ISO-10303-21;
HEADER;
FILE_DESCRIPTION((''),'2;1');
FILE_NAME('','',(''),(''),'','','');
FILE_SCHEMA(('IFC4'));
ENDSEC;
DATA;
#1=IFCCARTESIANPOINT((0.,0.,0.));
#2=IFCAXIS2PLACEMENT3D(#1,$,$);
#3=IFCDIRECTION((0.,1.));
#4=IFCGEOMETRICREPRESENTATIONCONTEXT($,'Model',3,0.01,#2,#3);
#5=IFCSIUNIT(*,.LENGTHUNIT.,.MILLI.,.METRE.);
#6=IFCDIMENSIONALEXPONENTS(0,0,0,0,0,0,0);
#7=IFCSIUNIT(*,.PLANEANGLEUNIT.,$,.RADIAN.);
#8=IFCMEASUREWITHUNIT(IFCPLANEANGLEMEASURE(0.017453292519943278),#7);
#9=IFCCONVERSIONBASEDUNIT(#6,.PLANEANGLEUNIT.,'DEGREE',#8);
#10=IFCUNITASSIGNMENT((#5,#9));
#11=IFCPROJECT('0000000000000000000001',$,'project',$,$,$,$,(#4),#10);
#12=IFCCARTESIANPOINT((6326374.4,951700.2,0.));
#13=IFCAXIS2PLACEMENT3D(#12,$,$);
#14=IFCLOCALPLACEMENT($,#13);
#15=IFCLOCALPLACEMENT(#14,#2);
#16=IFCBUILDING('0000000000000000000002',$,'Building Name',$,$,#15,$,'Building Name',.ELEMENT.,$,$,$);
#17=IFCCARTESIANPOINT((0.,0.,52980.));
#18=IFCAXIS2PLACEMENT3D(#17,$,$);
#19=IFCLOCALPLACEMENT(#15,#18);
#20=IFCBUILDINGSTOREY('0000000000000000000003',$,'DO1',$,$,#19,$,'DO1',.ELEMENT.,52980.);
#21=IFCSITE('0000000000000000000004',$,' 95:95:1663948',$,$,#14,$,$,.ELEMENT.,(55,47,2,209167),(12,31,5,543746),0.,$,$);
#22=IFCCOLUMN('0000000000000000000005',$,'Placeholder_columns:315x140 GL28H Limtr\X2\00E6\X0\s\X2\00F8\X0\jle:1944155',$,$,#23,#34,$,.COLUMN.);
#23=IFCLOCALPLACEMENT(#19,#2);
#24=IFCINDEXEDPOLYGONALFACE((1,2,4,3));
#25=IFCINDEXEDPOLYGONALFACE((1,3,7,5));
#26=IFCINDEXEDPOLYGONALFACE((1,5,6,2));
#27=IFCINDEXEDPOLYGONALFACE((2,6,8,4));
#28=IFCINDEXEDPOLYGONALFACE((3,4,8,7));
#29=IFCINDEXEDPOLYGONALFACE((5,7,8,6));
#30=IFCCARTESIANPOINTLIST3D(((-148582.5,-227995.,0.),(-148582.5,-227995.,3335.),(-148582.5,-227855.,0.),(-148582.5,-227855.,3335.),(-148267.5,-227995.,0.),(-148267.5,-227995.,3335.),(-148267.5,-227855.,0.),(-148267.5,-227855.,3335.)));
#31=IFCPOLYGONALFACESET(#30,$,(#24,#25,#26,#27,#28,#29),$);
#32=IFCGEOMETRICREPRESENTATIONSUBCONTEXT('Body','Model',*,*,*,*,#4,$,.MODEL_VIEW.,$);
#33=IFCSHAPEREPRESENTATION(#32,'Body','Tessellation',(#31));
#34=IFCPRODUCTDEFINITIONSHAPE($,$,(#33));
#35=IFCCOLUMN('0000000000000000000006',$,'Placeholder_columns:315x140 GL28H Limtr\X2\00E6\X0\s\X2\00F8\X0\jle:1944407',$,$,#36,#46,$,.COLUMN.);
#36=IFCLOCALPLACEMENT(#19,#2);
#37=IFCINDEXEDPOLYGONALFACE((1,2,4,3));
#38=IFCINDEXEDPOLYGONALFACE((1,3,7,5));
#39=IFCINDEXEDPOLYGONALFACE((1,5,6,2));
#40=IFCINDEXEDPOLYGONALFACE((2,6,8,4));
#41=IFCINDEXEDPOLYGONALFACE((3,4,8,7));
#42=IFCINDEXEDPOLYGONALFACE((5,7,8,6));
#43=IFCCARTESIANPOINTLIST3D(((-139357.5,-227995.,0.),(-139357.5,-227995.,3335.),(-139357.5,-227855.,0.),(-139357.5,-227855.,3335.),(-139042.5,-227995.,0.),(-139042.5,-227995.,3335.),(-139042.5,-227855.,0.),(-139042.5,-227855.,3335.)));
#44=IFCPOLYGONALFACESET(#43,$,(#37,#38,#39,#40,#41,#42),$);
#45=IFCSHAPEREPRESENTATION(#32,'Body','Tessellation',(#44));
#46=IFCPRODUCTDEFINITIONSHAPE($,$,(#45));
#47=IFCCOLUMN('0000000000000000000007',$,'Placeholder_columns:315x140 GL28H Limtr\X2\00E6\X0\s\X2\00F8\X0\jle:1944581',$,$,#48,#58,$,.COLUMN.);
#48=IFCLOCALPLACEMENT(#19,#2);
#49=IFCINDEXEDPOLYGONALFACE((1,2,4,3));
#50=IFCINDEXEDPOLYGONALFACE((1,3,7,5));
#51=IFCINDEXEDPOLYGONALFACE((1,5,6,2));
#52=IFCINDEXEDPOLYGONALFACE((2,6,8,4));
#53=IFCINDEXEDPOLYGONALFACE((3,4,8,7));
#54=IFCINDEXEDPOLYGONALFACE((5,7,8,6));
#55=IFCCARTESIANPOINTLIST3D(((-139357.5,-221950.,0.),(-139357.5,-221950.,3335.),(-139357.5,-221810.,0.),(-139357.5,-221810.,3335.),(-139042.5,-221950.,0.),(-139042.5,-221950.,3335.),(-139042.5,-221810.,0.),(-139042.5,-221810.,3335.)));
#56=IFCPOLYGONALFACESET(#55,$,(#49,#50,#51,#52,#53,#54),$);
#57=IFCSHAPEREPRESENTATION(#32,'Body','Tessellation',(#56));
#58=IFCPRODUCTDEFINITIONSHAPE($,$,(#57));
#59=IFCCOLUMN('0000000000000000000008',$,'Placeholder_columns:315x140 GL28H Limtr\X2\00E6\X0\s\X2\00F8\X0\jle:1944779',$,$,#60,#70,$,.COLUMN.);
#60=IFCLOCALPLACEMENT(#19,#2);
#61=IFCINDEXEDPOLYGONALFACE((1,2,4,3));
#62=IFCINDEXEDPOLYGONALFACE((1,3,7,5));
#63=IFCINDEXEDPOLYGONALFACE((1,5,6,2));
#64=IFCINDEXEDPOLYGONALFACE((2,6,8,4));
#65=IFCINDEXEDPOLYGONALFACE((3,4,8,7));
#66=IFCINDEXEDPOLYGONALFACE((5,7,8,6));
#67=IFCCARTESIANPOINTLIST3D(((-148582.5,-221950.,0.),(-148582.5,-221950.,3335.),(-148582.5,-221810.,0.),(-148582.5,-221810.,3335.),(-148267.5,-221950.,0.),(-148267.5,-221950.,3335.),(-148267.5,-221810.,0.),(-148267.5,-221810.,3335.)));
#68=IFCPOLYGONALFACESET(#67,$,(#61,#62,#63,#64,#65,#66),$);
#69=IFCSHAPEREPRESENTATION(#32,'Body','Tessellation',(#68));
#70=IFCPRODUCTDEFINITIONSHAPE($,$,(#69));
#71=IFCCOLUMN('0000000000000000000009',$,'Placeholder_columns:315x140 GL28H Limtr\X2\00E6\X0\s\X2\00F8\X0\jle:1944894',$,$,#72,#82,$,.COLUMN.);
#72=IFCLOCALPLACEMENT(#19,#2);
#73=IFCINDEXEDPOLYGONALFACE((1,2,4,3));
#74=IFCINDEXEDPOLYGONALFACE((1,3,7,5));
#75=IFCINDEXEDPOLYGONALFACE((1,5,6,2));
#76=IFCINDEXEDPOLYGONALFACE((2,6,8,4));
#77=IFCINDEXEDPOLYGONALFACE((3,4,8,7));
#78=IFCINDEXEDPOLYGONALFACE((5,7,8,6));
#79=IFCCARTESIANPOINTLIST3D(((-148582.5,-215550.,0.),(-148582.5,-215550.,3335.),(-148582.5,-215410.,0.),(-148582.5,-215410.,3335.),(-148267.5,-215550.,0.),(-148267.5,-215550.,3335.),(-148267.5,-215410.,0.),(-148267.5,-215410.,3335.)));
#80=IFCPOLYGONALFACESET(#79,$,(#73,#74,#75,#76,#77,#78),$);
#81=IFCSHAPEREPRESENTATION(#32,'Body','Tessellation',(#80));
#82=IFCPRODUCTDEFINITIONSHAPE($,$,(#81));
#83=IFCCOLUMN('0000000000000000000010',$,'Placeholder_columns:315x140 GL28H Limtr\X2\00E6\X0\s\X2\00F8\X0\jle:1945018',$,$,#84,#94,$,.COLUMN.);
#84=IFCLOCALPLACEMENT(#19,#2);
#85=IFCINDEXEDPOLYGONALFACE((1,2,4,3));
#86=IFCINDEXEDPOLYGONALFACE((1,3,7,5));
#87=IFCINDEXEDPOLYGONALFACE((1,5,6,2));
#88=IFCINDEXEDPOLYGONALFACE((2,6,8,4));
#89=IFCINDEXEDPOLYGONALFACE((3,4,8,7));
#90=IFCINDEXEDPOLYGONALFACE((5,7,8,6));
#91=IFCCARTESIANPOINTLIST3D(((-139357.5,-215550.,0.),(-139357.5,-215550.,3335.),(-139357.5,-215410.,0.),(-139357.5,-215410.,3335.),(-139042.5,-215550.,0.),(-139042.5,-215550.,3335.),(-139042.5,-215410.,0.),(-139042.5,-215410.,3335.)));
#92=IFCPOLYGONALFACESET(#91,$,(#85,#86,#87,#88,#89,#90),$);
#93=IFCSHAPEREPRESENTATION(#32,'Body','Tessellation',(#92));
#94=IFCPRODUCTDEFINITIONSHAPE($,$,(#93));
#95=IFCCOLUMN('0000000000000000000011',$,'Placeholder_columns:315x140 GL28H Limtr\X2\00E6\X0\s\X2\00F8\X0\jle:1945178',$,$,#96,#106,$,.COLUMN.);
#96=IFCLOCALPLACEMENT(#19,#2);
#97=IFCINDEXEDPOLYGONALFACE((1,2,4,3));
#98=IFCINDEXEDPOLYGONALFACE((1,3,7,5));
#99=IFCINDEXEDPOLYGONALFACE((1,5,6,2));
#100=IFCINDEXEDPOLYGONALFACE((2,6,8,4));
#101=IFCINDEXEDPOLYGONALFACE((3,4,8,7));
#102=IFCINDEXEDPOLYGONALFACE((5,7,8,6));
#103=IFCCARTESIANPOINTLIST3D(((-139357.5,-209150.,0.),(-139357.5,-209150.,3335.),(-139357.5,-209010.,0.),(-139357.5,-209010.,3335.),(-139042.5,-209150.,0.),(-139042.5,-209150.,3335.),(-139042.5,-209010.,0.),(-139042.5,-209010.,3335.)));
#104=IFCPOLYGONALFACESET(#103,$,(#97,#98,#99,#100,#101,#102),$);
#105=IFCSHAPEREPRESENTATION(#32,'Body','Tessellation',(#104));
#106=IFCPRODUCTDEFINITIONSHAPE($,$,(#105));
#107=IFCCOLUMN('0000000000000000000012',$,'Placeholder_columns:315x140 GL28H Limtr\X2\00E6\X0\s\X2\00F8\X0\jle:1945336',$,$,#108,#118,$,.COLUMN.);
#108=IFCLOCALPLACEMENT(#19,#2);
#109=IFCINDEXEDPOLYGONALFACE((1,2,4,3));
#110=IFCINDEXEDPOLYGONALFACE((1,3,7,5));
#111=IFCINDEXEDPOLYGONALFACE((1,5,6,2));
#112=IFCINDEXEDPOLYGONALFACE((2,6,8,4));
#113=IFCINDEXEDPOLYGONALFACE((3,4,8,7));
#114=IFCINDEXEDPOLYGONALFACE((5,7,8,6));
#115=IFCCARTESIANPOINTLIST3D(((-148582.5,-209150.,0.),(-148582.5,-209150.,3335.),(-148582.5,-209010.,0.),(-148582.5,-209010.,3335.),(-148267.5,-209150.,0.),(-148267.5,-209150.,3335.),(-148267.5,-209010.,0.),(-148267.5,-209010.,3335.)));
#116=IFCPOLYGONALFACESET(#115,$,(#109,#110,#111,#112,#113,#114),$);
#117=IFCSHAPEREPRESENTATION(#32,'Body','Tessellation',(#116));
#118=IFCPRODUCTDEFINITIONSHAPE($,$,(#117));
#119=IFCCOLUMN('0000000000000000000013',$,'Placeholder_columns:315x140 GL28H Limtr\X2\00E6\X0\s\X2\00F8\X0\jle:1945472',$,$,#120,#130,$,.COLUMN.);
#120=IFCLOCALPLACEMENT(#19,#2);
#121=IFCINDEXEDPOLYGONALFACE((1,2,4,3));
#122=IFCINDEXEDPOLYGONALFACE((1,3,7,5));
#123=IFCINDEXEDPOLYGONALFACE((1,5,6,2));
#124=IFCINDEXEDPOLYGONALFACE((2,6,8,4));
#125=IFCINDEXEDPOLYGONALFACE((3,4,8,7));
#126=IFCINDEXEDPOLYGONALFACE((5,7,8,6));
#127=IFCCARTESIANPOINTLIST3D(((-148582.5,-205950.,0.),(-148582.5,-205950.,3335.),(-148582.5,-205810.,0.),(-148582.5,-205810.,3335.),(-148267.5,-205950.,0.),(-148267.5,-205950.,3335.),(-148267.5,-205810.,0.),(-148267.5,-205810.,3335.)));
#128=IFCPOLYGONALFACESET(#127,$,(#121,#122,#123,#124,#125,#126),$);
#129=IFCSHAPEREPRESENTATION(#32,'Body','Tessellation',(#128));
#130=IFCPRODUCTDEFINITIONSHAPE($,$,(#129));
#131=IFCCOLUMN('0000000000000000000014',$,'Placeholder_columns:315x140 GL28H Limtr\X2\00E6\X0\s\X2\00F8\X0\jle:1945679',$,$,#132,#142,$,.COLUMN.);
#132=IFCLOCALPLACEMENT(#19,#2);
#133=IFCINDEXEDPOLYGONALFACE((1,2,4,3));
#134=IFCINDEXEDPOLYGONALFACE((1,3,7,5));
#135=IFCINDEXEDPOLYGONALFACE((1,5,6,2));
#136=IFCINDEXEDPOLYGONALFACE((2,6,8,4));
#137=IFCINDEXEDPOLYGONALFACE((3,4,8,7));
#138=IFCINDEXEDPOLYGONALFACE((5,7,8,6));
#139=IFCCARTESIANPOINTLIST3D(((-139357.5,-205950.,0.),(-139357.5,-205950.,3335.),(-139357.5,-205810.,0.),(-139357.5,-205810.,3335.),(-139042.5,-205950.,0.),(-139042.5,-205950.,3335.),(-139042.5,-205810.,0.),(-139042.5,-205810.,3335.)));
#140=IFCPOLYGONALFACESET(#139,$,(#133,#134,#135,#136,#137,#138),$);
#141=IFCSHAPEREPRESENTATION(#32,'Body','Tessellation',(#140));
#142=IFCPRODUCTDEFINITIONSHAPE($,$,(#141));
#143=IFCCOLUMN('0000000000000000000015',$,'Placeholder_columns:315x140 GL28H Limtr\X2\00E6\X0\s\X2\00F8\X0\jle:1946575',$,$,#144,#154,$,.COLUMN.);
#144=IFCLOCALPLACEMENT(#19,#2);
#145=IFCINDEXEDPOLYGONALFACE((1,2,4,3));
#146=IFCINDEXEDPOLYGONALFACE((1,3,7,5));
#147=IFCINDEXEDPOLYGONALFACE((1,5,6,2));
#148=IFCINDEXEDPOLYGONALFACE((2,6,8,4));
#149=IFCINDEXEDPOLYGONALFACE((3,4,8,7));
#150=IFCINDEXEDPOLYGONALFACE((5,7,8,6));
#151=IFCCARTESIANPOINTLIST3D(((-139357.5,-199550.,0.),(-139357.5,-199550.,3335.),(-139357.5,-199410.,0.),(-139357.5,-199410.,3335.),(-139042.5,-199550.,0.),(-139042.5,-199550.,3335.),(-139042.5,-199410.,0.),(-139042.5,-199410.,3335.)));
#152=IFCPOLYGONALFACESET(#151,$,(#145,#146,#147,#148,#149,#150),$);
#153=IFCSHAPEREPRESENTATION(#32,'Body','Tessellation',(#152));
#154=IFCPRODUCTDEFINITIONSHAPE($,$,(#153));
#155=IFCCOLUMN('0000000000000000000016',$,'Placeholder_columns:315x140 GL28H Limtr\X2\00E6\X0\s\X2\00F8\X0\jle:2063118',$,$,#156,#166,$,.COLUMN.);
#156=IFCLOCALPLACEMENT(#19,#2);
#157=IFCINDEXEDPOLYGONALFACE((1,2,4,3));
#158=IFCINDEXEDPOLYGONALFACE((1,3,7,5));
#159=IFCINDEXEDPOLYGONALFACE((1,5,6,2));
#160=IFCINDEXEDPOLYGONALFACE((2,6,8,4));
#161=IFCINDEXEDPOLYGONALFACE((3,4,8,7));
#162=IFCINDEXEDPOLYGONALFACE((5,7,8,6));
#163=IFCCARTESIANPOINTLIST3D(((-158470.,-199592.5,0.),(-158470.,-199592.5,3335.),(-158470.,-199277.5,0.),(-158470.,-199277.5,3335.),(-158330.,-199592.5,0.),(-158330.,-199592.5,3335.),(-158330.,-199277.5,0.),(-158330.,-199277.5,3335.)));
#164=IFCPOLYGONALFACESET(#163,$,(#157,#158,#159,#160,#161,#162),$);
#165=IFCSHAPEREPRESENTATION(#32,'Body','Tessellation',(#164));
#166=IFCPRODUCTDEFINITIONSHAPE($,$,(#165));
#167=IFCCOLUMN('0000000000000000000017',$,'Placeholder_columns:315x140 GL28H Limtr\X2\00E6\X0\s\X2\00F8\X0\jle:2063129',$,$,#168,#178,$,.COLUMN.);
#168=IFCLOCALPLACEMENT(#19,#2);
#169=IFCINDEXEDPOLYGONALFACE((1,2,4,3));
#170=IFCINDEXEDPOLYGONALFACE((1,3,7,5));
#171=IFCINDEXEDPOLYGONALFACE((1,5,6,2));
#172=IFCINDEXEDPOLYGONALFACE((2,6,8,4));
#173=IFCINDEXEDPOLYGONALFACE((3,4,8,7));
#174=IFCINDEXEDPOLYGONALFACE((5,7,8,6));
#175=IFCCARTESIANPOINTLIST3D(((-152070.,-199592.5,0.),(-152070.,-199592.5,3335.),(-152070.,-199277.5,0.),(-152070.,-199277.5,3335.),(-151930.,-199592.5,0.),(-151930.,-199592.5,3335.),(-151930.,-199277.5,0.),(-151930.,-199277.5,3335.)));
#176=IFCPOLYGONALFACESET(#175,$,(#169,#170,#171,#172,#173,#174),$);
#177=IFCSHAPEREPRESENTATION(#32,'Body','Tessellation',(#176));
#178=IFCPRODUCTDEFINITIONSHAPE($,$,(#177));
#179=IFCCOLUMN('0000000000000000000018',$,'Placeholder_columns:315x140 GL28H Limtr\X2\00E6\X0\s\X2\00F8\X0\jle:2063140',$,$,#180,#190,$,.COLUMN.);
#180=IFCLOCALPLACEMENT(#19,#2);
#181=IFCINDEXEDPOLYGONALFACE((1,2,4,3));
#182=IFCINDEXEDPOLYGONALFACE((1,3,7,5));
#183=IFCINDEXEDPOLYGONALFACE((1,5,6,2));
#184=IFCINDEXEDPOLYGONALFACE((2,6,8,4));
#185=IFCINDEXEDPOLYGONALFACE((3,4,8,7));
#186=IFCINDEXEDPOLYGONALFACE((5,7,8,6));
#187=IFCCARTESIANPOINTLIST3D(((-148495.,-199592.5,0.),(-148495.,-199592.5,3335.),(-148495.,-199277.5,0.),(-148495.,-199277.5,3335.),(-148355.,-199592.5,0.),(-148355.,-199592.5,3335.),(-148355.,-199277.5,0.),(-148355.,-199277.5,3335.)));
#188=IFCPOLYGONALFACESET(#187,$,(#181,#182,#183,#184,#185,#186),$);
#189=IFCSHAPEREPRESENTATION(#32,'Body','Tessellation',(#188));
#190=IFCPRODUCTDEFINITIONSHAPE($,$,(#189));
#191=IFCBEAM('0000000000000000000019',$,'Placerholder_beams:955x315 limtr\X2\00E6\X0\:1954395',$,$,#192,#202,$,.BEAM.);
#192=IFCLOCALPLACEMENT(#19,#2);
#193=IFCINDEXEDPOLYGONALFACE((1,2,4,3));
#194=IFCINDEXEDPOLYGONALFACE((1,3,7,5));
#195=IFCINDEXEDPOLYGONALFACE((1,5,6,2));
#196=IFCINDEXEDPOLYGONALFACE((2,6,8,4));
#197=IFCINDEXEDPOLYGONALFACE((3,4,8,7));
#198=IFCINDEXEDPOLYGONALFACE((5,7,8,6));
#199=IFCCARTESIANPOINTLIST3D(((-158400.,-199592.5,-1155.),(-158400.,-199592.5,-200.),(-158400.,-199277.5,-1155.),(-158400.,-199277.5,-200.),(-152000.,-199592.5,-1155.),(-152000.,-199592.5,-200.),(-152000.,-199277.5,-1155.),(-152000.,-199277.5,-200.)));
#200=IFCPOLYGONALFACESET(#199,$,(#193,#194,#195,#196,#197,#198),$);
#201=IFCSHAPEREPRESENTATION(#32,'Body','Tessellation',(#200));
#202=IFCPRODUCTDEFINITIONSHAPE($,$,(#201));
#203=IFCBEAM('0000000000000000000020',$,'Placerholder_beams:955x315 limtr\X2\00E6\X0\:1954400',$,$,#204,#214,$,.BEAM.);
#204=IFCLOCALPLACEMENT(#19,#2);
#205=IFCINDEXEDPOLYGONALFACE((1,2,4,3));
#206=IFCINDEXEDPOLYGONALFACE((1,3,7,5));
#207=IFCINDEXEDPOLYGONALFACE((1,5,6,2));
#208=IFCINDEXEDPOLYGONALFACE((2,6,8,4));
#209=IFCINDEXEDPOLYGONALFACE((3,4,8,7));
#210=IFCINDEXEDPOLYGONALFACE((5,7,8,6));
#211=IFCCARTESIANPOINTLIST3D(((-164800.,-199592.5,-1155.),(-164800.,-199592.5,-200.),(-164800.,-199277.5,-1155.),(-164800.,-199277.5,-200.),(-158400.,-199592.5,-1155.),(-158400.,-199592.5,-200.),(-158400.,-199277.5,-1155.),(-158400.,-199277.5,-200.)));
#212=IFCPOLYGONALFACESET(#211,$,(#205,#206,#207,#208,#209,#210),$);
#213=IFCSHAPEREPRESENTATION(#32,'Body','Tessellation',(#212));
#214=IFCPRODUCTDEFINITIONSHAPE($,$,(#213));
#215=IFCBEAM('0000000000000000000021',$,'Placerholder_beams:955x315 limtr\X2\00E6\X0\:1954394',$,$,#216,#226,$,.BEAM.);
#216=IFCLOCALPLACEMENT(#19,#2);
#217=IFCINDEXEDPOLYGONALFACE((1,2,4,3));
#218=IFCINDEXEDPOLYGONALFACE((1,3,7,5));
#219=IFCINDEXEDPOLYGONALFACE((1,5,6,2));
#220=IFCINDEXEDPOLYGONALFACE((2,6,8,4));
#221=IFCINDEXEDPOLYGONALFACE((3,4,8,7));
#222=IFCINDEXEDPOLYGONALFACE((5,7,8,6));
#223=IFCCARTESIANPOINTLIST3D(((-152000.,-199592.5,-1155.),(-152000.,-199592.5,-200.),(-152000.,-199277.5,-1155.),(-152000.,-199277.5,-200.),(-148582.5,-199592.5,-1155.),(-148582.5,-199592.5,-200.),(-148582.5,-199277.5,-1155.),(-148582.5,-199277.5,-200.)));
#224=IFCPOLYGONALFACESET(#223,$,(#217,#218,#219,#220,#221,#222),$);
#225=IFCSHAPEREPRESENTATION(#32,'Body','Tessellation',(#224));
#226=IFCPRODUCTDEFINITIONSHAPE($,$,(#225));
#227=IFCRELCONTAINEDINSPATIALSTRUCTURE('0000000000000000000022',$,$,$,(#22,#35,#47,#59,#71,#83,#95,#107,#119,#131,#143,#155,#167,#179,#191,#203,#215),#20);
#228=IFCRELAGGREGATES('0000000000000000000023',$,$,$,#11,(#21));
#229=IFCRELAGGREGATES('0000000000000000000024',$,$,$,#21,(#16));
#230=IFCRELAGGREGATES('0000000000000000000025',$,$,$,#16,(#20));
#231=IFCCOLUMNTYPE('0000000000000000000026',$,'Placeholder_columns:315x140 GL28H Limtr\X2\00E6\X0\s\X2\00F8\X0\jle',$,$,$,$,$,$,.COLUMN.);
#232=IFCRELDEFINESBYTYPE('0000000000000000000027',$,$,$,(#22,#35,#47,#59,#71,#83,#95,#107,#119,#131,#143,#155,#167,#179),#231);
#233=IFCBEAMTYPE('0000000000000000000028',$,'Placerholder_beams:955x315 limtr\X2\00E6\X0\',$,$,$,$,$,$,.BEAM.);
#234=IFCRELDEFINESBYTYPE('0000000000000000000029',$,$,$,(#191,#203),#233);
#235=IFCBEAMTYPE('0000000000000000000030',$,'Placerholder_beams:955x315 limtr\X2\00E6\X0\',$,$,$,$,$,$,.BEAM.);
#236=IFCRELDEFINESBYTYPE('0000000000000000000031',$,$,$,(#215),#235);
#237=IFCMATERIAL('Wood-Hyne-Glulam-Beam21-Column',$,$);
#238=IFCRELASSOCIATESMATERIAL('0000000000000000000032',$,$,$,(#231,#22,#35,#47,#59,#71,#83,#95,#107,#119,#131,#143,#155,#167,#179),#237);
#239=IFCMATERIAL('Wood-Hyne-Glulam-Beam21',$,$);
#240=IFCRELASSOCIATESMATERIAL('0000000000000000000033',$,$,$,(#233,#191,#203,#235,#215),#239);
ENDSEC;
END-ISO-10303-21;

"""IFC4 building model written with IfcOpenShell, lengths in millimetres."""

from ifc_helpers import new_model, entity, si_unit, converted_unit, direction, frame, origin, place, context, subcontext, project, spatial, indexed_curve, outline, extrude, source, transform, mapped, material, type_object, type_shapes, element, save


model = new_model("IFC4")

# Units and contexts
model_context = context("Model", 3, precision=0.01, world=origin(), true_north=direction((0.0, 1.0)))
body_context = subcontext(model_context, "Body", "Model", "MODEL_VIEW")
ifc_project = project(units=[si_unit("LENGTHUNIT", "METRE", prefix="MILLI"), converted_unit("PLANEANGLEUNIT", "DEGREE", entity("IfcPlaneAngleMeasure", 0.017453292519943278), si_unit("PLANEANGLEUNIT", "RADIAN"), dimensions=[0, 0, 0, 0, 0, 0, 0])], contexts=[model_context])

# Site, building, storey
site_placement = place(None, frame((6326374.4, 951700.2, 0.0)))
site = spatial("IfcSite", under=ifc_project, at=site_placement, Name=" 95:95:1663948", CompositionType="ELEMENT", RefLatitude=(55, 47, 2, 209167), RefLongitude=(12, 31, 5, 543746), RefElevation=0.0)
building_placement = place(site_placement, origin())
building = spatial("IfcBuilding", under=site, at=building_placement, Name="Building Name", LongName="Building Name", CompositionType="ELEMENT")
storey_placement = place(building_placement, frame((0.0, 0.0, 52980.0)))
storey = spatial("IfcBuildingStorey", under=building, at=storey_placement, Name="DO1", LongName="DO1", CompositionType="ELEMENT", Elevation=52980.0)

# Columns
ifc_material_1 = material(Name="Wood-Hyne-Glulam-Beam21-Column")
column_type = type_object("IfcColumnType", Name="Placeholder_columns:315x140 GL28H Limtræsøjle", PredefinedType="COLUMN", material=ifc_material_1)
shared_shape_1 = source(origin(), body_context, "Body", "SweptSolid", [
    extrude(outline(indexed_curve([(-157.5, -70.0), (157.5, -70.0), (157.5, 70.0), (-157.5, 70.0), (-157.5, -70.0)], self_intersect=False)), frame((0.0, 0.0, 52980.0), z_axis=(0.0, 0.0, 1.0), x_axis=(-1.0, 0.0, 0.0)), (0.0, 0.0, 1.0), 3335.0),
])
type_shapes(column_type, [shared_shape_1])
for number, where, name in (
    (1, (-148425.0, -227925.0, -52980.0), "Placeholder_columns:315x140 GL28H Limtræsøjle:1944155"),
    (2, (-139200.0, -227925.0, -52980.0), "Placeholder_columns:315x140 GL28H Limtræsøjle:1944407"),
    (3, (-139200.0, -221880.0, -52980.0), "Placeholder_columns:315x140 GL28H Limtræsøjle:1944581"),
    (4, (-148425.0, -221880.0, -52980.0), "Placeholder_columns:315x140 GL28H Limtræsøjle:1944779"),
    (5, (-148425.0, -215480.0, -52980.0), "Placeholder_columns:315x140 GL28H Limtræsøjle:1944894"),
    (6, (-139200.0, -215480.0, -52980.0), "Placeholder_columns:315x140 GL28H Limtræsøjle:1945018"),
    (7, (-139200.0, -209080.0, -52980.0), "Placeholder_columns:315x140 GL28H Limtræsøjle:1945178"),
    (8, (-148425.0, -209080.0, -52980.0), "Placeholder_columns:315x140 GL28H Limtræsøjle:1945336"),
    (9, (-148425.0, -205880.0, -52980.0), "Placeholder_columns:315x140 GL28H Limtræsøjle:1945472"),
    (10, (-139200.0, -205880.0, -52980.0), "Placeholder_columns:315x140 GL28H Limtræsøjle:1945679"),
    (11, (-139200.0, -199480.0, -52980.0), "Placeholder_columns:315x140 GL28H Limtræsøjle:1946575"),
):
    element("IfcColumn", number, at=place(storey_placement, frame(where)), inside=storey, type_object=column_type, material=ifc_material_1, Name=name, PredefinedType="COLUMN", context=body_context, shape_type="MappedRepresentation", body=[
        mapped(shared_shape_1, transform((0.0, 0.0, 0.0), scale=1.0)),
    ])
for number, where, z_axis, x_axis, name in (
    (12, (-158400.0, -199435.0, -52980.0), (0.0, 0.0, 1.0), (0.0, -1.0, 0.0), "Placeholder_columns:315x140 GL28H Limtræsøjle:2063118"),
    (13, (-152000.0, -199435.0, -52980.0), (0.0, 0.0, 1.0), (0.0, -1.0, 0.0), "Placeholder_columns:315x140 GL28H Limtræsøjle:2063129"),
    (14, (-148425.0, -199435.0, -52980.0), (0.0, 0.0, 1.0), (0.0, -1.0, 0.0), "Placeholder_columns:315x140 GL28H Limtræsøjle:2063140"),
):
    element("IfcColumn", number, at=place(storey_placement, frame(where, z_axis=z_axis, x_axis=x_axis)), inside=storey, type_object=column_type, material=ifc_material_1, Name=name, PredefinedType="COLUMN", context=body_context, shape_type="MappedRepresentation", body=[
        mapped(shared_shape_1, transform((0.0, 0.0, 0.0), scale=1.0)),
    ])

# Beams
ifc_material_2 = material(Name="Wood-Hyne-Glulam-Beam21")
beam_type_1 = type_object("IfcBeamType", Name="Placerholder_beams:955x315 limtræ", PredefinedType="BEAM", material=ifc_material_2)
shared_shape_2 = source(origin(), body_context, "Body", "SweptSolid", [
    extrude(outline(indexed_curve([(-3200.0, -157.5), (3200.0, -157.5), (3200.0, 157.5), (-3200.0, 157.5), (-3200.0, -157.5)], self_intersect=False)), frame((0.0, 0.0, -477.5)), (0.0, 0.0, 1.0), 955.0),
])
type_shapes(beam_type_1, [shared_shape_2])
beam_1_placement = place(storey_placement, frame((-155200.0, -199435.0, -677.5), z_axis=(0.0, 0.0, 1.0), x_axis=(-1.0, 0.0, 0.0)))
element("IfcBeam", 15, at=beam_1_placement, inside=storey, type_object=beam_type_1, material=ifc_material_2, Name="Placerholder_beams:955x315 limtræ:1954395", PredefinedType="BEAM", context=body_context, shape_type="MappedRepresentation", body=[
    mapped(shared_shape_2, transform((0.0, 0.0, 0.0), scale=1.0)),
])
beam_2_placement = place(storey_placement, frame((-161600.0, -199435.0, -677.5)))
element("IfcBeam", 16, at=beam_2_placement, inside=storey, type_object=beam_type_1, material=ifc_material_2, Name="Placerholder_beams:955x315 limtræ:1954400", PredefinedType="BEAM", context=body_context, shape_type="MappedRepresentation", body=[
    mapped(shared_shape_2, transform((0.0, 0.0, 0.0), scale=1.0)),
])
beam_type_2 = type_object("IfcBeamType", Name="Placerholder_beams:955x315 limtræ", PredefinedType="BEAM", material=ifc_material_2)
shared_shape_3 = source(origin(), body_context, "Body", "SweptSolid", [
    extrude(outline(indexed_curve([(-1708.8, -157.5), (1708.8, -157.5), (1708.8, 157.5), (-1708.8, 157.5), (-1708.8, -157.5)], self_intersect=False)), frame((78.8, 0.0, -477.5)), (0.0, 0.0, 1.0), 955.0),
])
type_shapes(beam_type_2, [shared_shape_3])
beam_3_placement = place(storey_placement, frame((-150212.5, -199435.0, -677.5), z_axis=(0.0, 0.0, 1.0), x_axis=(-1.0, 0.0, 0.0)))
element("IfcBeam", 17, at=beam_3_placement, inside=storey, type_object=beam_type_2, material=ifc_material_2, Name="Placerholder_beams:955x315 limtræ:1954394", PredefinedType="BEAM", context=body_context, shape_type="MappedRepresentation", body=[
    mapped(shared_shape_3, transform((0.0, 0.0, 0.0), scale=1.0)),
])

save(model, "model.ifc")
